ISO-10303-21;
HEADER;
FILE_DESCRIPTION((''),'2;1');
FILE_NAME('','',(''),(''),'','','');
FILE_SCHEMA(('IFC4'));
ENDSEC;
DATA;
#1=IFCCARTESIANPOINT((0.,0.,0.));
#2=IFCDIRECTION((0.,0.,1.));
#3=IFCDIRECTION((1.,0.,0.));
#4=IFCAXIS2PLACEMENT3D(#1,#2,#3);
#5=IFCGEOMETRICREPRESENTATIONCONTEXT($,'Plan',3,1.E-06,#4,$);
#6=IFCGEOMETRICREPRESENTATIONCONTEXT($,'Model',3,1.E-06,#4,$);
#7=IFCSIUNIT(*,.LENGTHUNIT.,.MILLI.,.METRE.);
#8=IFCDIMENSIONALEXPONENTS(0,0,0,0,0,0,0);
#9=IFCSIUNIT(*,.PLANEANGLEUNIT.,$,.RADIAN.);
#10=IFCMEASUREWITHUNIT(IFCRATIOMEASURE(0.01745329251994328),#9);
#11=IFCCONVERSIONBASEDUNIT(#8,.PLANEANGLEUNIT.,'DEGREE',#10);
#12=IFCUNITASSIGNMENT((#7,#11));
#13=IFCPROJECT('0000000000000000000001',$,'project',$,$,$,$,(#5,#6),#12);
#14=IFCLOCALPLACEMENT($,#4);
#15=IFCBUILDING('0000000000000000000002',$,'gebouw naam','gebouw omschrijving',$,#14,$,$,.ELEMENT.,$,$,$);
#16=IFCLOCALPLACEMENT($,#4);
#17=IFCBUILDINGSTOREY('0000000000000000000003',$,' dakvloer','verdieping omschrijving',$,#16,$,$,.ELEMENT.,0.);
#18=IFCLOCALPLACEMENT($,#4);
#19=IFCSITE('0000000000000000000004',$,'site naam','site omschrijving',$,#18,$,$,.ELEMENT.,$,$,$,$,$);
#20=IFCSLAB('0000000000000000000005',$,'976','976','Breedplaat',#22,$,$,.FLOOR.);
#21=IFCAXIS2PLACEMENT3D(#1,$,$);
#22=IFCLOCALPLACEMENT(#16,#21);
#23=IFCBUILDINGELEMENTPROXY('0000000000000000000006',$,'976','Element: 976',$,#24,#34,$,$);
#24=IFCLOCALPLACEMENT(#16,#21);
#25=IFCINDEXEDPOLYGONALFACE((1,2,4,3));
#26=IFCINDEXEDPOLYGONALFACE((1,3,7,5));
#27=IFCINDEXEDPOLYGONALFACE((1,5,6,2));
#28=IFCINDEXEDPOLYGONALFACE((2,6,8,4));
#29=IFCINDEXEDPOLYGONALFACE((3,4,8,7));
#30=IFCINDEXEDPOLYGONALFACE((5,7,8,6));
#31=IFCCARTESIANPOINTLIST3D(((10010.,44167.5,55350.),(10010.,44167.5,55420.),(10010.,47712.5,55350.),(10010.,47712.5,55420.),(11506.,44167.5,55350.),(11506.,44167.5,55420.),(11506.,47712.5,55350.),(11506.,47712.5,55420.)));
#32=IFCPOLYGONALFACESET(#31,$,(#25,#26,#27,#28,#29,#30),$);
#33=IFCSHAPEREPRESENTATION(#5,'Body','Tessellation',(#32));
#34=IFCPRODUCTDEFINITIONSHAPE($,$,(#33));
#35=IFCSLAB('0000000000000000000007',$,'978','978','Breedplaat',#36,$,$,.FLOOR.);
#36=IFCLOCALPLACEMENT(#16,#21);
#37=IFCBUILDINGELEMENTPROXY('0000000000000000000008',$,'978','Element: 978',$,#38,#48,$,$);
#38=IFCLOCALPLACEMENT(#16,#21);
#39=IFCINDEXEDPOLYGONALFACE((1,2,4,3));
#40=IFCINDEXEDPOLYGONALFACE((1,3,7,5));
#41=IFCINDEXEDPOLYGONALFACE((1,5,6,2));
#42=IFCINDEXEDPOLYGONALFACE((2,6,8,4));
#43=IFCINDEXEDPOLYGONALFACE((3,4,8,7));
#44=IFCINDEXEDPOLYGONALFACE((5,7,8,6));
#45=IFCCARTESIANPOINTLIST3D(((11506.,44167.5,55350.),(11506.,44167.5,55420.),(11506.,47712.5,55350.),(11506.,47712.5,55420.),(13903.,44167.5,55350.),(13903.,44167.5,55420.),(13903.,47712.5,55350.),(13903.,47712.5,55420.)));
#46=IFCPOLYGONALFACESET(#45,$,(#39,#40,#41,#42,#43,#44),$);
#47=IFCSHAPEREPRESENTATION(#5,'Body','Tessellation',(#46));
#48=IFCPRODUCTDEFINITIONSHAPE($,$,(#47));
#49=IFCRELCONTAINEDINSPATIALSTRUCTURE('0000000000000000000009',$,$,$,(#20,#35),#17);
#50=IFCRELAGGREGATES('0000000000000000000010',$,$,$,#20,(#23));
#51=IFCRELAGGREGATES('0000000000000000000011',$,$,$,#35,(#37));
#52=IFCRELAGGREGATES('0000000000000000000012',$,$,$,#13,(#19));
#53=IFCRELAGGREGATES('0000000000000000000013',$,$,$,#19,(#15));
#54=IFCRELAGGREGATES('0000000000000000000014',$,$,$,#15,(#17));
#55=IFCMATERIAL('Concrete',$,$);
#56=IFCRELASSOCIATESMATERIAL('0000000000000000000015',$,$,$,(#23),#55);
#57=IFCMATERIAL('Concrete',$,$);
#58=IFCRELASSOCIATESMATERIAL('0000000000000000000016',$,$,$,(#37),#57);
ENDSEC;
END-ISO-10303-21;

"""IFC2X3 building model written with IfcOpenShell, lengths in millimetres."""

from ifc_helpers import new_model, entity, si_unit, converted_unit, frame, origin_with_axes, place, context, project, spatial, polyline, outline, extrude, material, element, aggregate, save


model = new_model("IFC2X3")

# Units and contexts
plan_context = context("Plan", 3, precision=1e-06, world=origin_with_axes())
model_context = context("Model", 3, precision=1e-06, world=origin_with_axes())
ifc_project = project(units=[si_unit("LENGTHUNIT", "METRE", prefix="MILLI"), converted_unit("PLANEANGLEUNIT", "DEGREE", entity("IfcRatioMeasure", 0.01745329251994328), si_unit("PLANEANGLEUNIT", "RADIAN"), dimensions=[0, 0, 0, 0, 0, 0, 0])], contexts=[plan_context, model_context])

# Site, building, storey
site_placement = place(None, origin_with_axes())
site = spatial("IfcSite", under=ifc_project, at=site_placement, Name="site naam", Description="site omschrijving", CompositionType="ELEMENT")
building_placement = place(None, origin_with_axes())
building = spatial("IfcBuilding", under=site, at=building_placement, Name="gebouw naam", Description="gebouw omschrijving", CompositionType="ELEMENT")
storey_placement = place(None, origin_with_axes())
storey = spatial("IfcBuildingStorey", under=building, at=storey_placement, Name=" dakvloer", Description="verdieping omschrijving", CompositionType="ELEMENT", Elevation=0.0)

# Slab, building element proxy, opening
slab_1_placement = place(None, frame((10010.0, 47712.5, 55350.0), z_axis=(0.0, 0.0, 1.0), x_axis=(0.0, -1.0, 0.0)))
slab_1 = element("IfcSlab", 1, at=slab_1_placement, inside=storey, Name="976", Description="976", ObjectType="Breedplaat", PredefinedType="FLOOR")
ifc_material_1 = material(Name="Concrete")
proxy_1_placement = place(slab_1_placement, origin_with_axes())
proxy_1 = element("IfcBuildingElementProxy", 2, at=proxy_1_placement, material=ifc_material_1, Name="976", Description="Element: 976", context=plan_context, shape_type="SweptSolid", body=[
    extrude(outline(polyline([(3545.0, 0.0), (3545.0, 1496.0), (0.0, 1496.0), (0.0, 0.0), (3545.0, 0.0)])), origin_with_axes(), (0.0, 0.0, 1.0), 70.0),
])
opening_1_placement = place(None, frame((10010.0, 47712.5, 55350.0), z_axis=(0.0, 0.0, 1.0), x_axis=(0.0, -1.0, 0.0)))
element("IfcOpeningElement", 3, at=opening_1_placement, cuts=proxy_1, ObjectType="Opening", context=plan_context, shape_type="SweptSolid", body=[
    extrude(outline(polyline([(-0.1, -0.1), (-0.1, 10.0), (10.0, -0.1), (-0.1, -0.1)])), frame((3546.2, 1496.2, -0.1), z_axis=(-1.0, 0.0, 0.0), x_axis=(0.0, -1.0, 0.0)), (0.0, 0.0, 1.0), 3547.2),
])
aggregate(slab_1, [proxy_1])

# Slab, building element proxy, openings
slab_2_placement = place(None, frame((11506.0, 47712.5, 55350.0), z_axis=(0.0, 0.0, 1.0), x_axis=(0.0, -1.0, 0.0)))
slab_2 = element("IfcSlab", 4, at=slab_2_placement, inside=storey, Name="978", Description="978", ObjectType="Breedplaat", PredefinedType="FLOOR")
ifc_material_2 = material(Name="Concrete")
proxy_2_placement = place(slab_2_placement, origin_with_axes())
proxy_2 = element("IfcBuildingElementProxy", 5, at=proxy_2_placement, material=ifc_material_2, Name="978", Description="Element: 978", context=plan_context, shape_type="SweptSolid", body=[
    extrude(outline(polyline([(0.0, 2397.0), (0.0, 0.0), (3545.0, 0.0), (3545.0, 2397.0), (0.0, 2397.0)])), origin_with_axes(), (0.0, 0.0, 1.0), 70.0),
])
opening_2_placement = place(None, frame((11506.0, 47712.5, 55350.0), z_axis=(0.0, 0.0, 1.0), x_axis=(0.0, -1.0, 0.0)))
element("IfcOpeningElement", 6, at=opening_2_placement, cuts=proxy_2, ObjectType="Opening", context=plan_context, shape_type="SweptSolid", body=[
    extrude(outline(polyline([(-0.1, -0.1), (-0.1, 10.0), (10.0, -0.1), (-0.1, -0.1)])), frame((-1.2, -0.1, -0.1), z_axis=(1.0, 0.0, 0.0), x_axis=(0.0, 1.0, 0.0)), (0.0, 0.0, 1.0), 3547.2),
])
opening_3_placement = place(None, frame((11506.0, 47712.5, 55350.0), z_axis=(0.0, 0.0, 1.0), x_axis=(0.0, -1.0, 0.0)))
element("IfcOpeningElement", 7, at=opening_3_placement, cuts=proxy_2, ObjectType="Opening", context=plan_context, shape_type="SweptSolid", body=[
    extrude(outline(polyline([(-0.1, -0.1), (-0.1, 10.0), (10.0, -0.1), (-0.1, -0.1)])), frame((3546.2, 2397.2, -0.1), z_axis=(-1.0, 0.0, 0.0), x_axis=(0.0, -1.0, 0.0)), (0.0, 0.0, 1.0), 3547.2),
])
aggregate(slab_2, [proxy_2])

save(model, "model.ifc")
